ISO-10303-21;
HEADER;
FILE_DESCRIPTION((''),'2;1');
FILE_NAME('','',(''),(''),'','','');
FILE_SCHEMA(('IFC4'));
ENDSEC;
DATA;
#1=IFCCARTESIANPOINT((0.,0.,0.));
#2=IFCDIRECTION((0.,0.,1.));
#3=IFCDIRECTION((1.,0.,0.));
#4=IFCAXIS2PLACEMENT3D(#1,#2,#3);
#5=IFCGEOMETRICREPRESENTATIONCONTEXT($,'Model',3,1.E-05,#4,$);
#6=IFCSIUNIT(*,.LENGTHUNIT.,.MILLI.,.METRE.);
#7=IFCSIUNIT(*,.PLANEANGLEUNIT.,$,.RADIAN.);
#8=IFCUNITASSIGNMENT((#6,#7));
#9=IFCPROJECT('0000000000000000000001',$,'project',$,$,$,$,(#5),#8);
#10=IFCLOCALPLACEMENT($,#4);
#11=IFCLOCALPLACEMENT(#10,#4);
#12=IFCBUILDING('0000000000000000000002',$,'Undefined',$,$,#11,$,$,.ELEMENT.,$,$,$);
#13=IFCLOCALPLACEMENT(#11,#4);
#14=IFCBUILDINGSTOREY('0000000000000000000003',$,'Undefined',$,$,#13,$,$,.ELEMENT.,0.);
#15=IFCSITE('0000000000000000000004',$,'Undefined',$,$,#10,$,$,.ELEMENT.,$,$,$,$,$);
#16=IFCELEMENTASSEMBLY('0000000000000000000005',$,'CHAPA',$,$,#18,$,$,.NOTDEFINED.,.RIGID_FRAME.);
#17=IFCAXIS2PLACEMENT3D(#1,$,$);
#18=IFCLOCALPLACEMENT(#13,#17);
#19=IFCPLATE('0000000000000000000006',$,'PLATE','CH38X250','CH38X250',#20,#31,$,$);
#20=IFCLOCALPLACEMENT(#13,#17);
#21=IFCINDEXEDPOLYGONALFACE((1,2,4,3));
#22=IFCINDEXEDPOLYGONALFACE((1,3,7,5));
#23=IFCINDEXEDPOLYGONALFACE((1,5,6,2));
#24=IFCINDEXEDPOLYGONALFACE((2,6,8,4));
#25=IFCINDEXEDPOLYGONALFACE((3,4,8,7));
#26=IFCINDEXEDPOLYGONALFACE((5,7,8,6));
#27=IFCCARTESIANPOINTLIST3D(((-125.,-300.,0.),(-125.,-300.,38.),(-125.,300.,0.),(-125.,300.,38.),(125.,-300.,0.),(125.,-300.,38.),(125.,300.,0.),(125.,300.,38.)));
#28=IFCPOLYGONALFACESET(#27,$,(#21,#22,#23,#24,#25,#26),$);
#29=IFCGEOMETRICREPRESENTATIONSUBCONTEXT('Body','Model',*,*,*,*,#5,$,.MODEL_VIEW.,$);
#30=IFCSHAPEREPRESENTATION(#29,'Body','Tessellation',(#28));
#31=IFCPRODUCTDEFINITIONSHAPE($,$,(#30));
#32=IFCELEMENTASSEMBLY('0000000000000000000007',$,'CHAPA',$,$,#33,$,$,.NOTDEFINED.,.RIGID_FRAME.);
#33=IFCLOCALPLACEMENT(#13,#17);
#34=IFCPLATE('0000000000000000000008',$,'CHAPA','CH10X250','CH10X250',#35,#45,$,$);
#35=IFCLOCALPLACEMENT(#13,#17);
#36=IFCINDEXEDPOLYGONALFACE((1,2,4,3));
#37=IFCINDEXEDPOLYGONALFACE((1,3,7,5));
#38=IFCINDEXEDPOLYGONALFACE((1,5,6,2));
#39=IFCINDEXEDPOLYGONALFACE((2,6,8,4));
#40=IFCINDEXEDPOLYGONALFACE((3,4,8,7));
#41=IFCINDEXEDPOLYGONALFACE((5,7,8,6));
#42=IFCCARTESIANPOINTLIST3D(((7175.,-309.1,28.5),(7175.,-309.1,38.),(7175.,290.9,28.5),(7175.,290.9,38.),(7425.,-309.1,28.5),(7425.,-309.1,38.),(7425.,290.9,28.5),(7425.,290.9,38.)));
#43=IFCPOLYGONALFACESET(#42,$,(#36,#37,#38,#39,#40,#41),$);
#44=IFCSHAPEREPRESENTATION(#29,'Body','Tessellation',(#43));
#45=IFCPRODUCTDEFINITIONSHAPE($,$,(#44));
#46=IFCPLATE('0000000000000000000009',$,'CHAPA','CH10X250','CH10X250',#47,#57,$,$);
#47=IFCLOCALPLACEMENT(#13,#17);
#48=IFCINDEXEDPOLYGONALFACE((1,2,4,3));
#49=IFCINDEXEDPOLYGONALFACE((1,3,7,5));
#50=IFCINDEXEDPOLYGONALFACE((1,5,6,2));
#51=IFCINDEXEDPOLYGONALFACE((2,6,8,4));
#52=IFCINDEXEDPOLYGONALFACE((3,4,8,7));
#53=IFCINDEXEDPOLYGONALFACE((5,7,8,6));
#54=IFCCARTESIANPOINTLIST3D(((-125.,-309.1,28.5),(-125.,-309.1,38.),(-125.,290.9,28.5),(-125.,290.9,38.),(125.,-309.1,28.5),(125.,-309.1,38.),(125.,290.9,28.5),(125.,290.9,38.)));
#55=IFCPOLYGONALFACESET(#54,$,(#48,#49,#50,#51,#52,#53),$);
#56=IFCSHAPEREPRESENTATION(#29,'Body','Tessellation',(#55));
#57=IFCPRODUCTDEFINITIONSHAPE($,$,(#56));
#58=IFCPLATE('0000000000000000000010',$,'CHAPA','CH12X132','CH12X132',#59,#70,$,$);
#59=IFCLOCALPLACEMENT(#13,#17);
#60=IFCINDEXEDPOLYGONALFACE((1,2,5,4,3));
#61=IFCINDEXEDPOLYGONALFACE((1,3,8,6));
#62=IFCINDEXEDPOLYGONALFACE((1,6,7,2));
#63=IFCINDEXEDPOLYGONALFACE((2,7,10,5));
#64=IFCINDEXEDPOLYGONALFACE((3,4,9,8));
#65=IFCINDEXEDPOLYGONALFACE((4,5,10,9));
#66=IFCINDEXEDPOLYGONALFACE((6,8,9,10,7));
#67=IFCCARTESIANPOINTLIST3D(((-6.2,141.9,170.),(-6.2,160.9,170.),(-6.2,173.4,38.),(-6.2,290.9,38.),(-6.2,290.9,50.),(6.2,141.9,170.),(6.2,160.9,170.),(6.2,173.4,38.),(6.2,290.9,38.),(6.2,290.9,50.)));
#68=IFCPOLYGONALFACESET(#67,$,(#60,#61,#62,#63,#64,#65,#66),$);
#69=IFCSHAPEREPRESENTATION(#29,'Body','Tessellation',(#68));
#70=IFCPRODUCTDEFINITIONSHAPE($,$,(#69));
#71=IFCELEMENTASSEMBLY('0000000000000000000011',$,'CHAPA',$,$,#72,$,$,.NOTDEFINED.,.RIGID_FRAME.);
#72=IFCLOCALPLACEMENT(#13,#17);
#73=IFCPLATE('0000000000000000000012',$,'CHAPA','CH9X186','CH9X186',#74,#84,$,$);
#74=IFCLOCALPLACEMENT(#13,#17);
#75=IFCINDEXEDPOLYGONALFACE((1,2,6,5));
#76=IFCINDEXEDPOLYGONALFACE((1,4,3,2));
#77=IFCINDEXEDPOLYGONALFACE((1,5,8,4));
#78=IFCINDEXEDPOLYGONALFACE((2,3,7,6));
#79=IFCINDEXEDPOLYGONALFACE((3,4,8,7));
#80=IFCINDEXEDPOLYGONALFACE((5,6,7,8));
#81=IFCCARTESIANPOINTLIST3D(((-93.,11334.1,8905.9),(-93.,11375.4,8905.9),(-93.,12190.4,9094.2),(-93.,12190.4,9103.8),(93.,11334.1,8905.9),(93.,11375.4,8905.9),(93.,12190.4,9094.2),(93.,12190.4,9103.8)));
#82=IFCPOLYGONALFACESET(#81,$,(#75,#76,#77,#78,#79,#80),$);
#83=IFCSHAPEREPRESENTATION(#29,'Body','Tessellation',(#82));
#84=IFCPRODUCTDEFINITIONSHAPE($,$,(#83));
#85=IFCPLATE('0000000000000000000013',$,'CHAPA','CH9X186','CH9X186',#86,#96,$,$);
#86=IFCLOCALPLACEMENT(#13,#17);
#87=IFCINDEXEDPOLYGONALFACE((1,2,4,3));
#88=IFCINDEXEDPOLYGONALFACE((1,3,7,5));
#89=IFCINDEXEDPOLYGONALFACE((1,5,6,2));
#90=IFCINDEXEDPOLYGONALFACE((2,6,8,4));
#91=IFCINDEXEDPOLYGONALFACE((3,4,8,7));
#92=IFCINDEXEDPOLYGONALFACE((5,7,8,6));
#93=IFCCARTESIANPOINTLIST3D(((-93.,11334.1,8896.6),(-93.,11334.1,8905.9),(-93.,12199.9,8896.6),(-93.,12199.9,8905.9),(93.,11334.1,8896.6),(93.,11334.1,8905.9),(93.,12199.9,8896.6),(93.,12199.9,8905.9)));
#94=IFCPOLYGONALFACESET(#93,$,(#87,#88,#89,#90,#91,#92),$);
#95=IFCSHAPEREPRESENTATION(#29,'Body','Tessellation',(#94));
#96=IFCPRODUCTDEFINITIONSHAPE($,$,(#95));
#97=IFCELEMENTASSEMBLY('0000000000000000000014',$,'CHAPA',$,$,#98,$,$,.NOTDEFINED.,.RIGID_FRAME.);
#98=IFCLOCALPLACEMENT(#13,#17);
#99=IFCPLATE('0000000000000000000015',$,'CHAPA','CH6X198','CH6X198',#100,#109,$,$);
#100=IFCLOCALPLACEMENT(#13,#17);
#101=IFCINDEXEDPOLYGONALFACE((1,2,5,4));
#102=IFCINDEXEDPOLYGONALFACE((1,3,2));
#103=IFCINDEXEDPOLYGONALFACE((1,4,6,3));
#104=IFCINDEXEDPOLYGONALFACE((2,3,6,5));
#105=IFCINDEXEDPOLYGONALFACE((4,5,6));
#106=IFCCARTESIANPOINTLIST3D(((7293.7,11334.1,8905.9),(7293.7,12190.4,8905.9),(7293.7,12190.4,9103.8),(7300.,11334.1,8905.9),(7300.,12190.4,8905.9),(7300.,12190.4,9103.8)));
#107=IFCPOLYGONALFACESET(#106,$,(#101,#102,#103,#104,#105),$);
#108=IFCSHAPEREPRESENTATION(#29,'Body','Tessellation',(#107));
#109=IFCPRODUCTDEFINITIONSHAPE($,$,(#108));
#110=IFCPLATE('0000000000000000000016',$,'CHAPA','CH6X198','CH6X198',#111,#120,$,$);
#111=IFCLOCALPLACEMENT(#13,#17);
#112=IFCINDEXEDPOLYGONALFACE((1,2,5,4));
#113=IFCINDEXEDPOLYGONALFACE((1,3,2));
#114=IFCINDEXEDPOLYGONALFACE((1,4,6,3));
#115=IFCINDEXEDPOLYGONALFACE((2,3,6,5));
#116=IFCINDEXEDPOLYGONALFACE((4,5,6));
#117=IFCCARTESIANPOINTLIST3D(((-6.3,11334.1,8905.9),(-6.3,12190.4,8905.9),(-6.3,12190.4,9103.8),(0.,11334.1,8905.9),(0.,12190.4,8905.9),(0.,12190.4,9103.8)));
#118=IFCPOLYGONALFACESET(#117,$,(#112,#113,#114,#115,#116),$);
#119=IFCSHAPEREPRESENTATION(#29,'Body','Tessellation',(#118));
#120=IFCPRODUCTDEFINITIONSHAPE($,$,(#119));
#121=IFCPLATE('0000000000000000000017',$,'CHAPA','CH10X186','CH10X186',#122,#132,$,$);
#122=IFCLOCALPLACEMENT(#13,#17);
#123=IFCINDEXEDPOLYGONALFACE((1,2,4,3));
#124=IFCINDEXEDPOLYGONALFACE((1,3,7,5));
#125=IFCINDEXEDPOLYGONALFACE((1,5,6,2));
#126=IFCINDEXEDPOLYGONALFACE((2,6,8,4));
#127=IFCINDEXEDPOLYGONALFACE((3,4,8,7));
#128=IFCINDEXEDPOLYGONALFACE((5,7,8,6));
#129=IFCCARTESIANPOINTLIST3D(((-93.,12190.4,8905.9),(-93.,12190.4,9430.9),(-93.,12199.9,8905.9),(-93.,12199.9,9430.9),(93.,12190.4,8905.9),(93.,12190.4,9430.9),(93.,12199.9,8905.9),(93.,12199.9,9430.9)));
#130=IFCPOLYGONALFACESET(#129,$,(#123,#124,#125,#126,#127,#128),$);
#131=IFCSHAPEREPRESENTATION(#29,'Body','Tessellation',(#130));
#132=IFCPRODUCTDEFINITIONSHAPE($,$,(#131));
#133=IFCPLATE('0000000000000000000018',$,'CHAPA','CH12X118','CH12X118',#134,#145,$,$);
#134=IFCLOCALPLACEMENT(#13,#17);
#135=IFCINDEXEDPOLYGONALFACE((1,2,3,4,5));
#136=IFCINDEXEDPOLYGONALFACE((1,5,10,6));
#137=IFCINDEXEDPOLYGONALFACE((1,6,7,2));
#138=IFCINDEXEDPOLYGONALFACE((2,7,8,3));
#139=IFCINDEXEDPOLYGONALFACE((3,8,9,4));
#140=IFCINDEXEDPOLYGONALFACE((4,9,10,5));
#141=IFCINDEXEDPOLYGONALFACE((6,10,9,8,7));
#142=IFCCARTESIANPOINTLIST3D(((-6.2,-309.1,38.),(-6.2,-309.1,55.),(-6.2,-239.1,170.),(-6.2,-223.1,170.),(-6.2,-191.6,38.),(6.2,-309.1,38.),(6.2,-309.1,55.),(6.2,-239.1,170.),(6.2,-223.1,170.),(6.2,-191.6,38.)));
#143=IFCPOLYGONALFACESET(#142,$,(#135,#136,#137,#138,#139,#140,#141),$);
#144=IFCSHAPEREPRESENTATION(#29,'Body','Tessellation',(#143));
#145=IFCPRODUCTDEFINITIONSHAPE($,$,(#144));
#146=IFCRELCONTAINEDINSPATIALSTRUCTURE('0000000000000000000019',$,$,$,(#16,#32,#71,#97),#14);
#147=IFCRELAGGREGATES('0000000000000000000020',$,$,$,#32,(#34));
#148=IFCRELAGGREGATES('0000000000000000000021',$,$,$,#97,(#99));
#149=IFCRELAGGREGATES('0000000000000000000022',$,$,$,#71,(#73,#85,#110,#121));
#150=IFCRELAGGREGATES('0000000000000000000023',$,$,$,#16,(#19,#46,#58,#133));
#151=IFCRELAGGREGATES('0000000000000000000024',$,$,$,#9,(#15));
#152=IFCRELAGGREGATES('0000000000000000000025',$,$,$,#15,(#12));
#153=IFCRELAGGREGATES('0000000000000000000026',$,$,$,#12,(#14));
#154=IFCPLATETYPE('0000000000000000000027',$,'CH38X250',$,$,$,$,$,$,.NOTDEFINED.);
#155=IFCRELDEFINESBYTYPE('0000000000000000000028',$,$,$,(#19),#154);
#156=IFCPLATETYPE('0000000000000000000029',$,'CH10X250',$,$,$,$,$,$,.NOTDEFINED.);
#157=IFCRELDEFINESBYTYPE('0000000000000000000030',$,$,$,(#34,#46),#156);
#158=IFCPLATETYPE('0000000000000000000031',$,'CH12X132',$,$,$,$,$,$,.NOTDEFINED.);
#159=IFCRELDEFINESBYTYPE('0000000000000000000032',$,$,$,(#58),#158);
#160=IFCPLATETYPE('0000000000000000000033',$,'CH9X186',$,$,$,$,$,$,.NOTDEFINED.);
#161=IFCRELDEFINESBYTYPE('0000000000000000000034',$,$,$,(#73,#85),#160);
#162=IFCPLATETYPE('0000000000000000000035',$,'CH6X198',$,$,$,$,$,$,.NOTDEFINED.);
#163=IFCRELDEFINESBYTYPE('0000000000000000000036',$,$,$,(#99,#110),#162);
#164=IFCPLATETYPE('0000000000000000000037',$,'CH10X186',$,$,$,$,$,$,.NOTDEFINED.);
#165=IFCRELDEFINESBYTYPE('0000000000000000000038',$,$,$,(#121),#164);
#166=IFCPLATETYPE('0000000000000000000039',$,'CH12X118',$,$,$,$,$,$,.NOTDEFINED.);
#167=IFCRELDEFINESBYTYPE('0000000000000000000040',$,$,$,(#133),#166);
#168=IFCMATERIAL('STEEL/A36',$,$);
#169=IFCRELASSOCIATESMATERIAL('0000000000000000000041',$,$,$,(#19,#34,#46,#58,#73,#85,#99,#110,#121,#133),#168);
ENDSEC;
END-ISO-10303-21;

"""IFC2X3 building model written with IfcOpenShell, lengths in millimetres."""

from ifc_helpers import new_model, si_unit, frame, origin_with_axes, place, context, subcontext, project, spatial, polyline, outline, extrude, clip, halfspace, material, type_object, element, aggregate, save


model = new_model("IFC2X3")

# Units and contexts
model_context = context("Model", 3, precision=1e-05, world=origin_with_axes())
body_context = subcontext(model_context, "Body", "Model", "MODEL_VIEW")
ifc_project = project(units=[si_unit("LENGTHUNIT", "METRE", prefix="MILLI"), si_unit("PLANEANGLEUNIT", "RADIAN")], contexts=[model_context])

# Site, building, storey
site_placement = place(None, origin_with_axes())
site = spatial("IfcSite", under=ifc_project, at=site_placement, Name="Undefined", CompositionType="ELEMENT")
building_placement = place(site_placement, origin_with_axes())
building = spatial("IfcBuilding", under=site, at=building_placement, Name="Undefined", CompositionType="ELEMENT")
storey_placement = place(building_placement, origin_with_axes())
storey = spatial("IfcBuildingStorey", under=building, at=storey_placement, Name="Undefined", CompositionType="ELEMENT", Elevation=0.0)

# Element assembly, plate
assembly_1_placement = place(storey_placement, origin_with_axes())
assembly_1 = element("IfcElementAssembly", 1, at=assembly_1_placement, inside=storey, Name="CHAPA", AssemblyPlace="NOTDEFINED", PredefinedType="RIGID_FRAME")
ifc_material_1 = material(Name="STEEL/A36")
plate_type_1 = type_object("IfcPlateType", Name="CH38X250", PredefinedType="NOTDEFINED")
plate_1_placement = place(assembly_1_placement, frame((125.0, -300.0, 19.0), z_axis=(0.0, 0.0, 1.0), x_axis=(0.0, 1.0, 0.0)))
plate_1 = element("IfcPlate", 2, at=plate_1_placement, type_object=plate_type_1, material=ifc_material_1, Name="PLATE", Description="CH38X250", ObjectType="CH38X250", context=body_context, shape_type="SweptSolid", body=[
    extrude(outline(polyline([(0.0, 0.0), (600.0, 0.0), (600.0, 250.0), (0.0, 250.0), (0.0, 0.0)])), frame((0.0, 0.0, -19.0), z_axis=(0.0, 0.0, 1.0), x_axis=(1.0, 0.0, 0.0)), (0.0, 0.0, 1.0), 38.0),
])

# Element assembly, plate
assembly_2_placement = place(storey_placement, origin_with_axes())
assembly_2 = element("IfcElementAssembly", 3, at=assembly_2_placement, inside=storey, Name="CHAPA", AssemblyPlace="NOTDEFINED", PredefinedType="RIGID_FRAME")
plate_type_2 = type_object("IfcPlateType", Name="CH10X250", PredefinedType="NOTDEFINED")
plate_2_placement = place(assembly_2_placement, frame((7175.0, -309.1, 33.2), z_axis=(0.0, 0.0, 1.0), x_axis=(1.0, 0.0, 0.0)))
plate_2 = element("IfcPlate", 4, at=plate_2_placement, type_object=plate_type_2, material=ifc_material_1, Name="CHAPA", Description="CH10X250", ObjectType="CH10X250", context=body_context, shape_type="SweptSolid", body=[
    extrude(outline(polyline([(0.0, 0.0), (250.0, 0.0), (250.0, 600.0), (0.0, 600.0), (0.0, 0.0)])), frame((0.0, 0.0, -4.8), z_axis=(0.0, 0.0, 1.0), x_axis=(1.0, 0.0, 0.0)), (0.0, 0.0, 1.0), 9.5),
])
aggregate(assembly_2, [plate_2])

# Plates
plate_3_placement = place(assembly_1_placement, frame((-125.0, -309.1, 33.2), z_axis=(0.0, 0.0, 1.0), x_axis=(1.0, 0.0, 0.0)))
plate_3 = element("IfcPlate", 5, at=plate_3_placement, type_object=plate_type_2, material=ifc_material_1, Name="CHAPA", Description="CH10X250", ObjectType="CH10X250", context=body_context, shape_type="SweptSolid", body=[
    extrude(outline(polyline([(0.0, 0.0), (250.0, 0.0), (250.0, 600.0), (0.0, 600.0), (0.0, 0.0)])), frame((0.0, 0.0, -4.8), z_axis=(0.0, 0.0, 1.0), x_axis=(1.0, 0.0, 0.0)), (0.0, 0.0, 1.0), 9.5),
])
plate_type_3 = type_object("IfcPlateType", Name="CH12X132", PredefinedType="NOTDEFINED")
plate_4_placement = place(assembly_1_placement, frame((0.0, 173.4, 38.0), z_axis=(1.0, 0.0, 0.0), x_axis=(0.0, 1.0, 0.0)))
plate_4 = element("IfcPlate", 6, at=plate_4_placement, type_object=plate_type_3, material=ifc_material_1, Name="CHAPA", Description="CH12X132", ObjectType="CH12X132", context=body_context, shape_type="SweptSolid", body=[
    extrude(outline(polyline([(0.0, 0.0), (117.5, 0.0), (117.5, 12.0), (-12.5, 132.0), (-31.6, 132.0), (0.0, 0.0)])), frame((0.0, 0.0, -6.2), z_axis=(0.0, 0.0, 1.0), x_axis=(1.0, 0.0, 0.0)), (0.0, 0.0, 1.0), 12.5),
])

# Element assembly, plates
assembly_3_placement = place(storey_placement, origin_with_axes())
assembly_3 = element("IfcElementAssembly", 7, at=assembly_3_placement, inside=storey, Name="CHAPA", AssemblyPlace="NOTDEFINED", PredefinedType="RIGID_FRAME")
plate_type_4 = type_object("IfcPlateType", Name="CH9X186", PredefinedType="NOTDEFINED")
plate_5_placement = place(assembly_3_placement, frame((93.0, 12191.4, 9099.3), z_axis=(0.0, -0.225125, 0.97433), x_axis=(-1.0, 0.0, 0.0)))
plate_5 = element("IfcPlate", 8, at=plate_5_placement, type_object=plate_type_4, material=ifc_material_1, Name="CHAPA", Description="CH9X186", ObjectType="CH9X186", context=body_context, shape_type="Clipping", body=[
    clip(clip(extrude(outline(polyline([(0.0, 0.0), (186.0, 0.0), (186.0, 878.9), (0.0, 878.9), (0.0, 0.0)])), frame((0.0, 0.0, -4.7), z_axis=(0.0, 0.0, 1.0), x_axis=(1.0, 0.0, 0.0)), (0.0, 0.0, 1.0), 9.3), halfspace(frame((186.0, -500.0, -314.0), z_axis=(0.0, 0.225128, -0.974329), x_axis=(0.0, 0.974329, 0.225128)), False)), halfspace(frame((0.0, 2.1, -4.6), z_axis=(0.0, -0.97433, -0.225125), x_axis=(0.0, -0.225125, 0.97433)), False)),
])
plate_6_placement = place(assembly_3_placement, frame((93.0, 12199.9, 8901.3), z_axis=(0.0, 0.0, 1.0), x_axis=(-1.0, 0.0, 0.0)))
plate_6 = element("IfcPlate", 9, at=plate_6_placement, type_object=plate_type_4, material=ifc_material_1, Name="CHAPA", Description="CH9X186", ObjectType="CH9X186", context=body_context, shape_type="SweptSolid", body=[
    extrude(outline(polyline([(0.0, 0.0), (186.0, 0.0), (186.0, 865.8), (0.0, 865.8), (0.0, 0.0)])), frame((0.0, 0.0, -4.7), z_axis=(0.0, 0.0, 1.0), x_axis=(1.0, 0.0, 0.0)), (0.0, 0.0, 1.0), 9.3),
])

# Element assembly, plate
assembly_4_placement = place(storey_placement, origin_with_axes())
assembly_4 = element("IfcElementAssembly", 10, at=assembly_4_placement, inside=storey, Name="CHAPA", AssemblyPlace="NOTDEFINED", PredefinedType="RIGID_FRAME")
plate_type_5 = type_object("IfcPlateType", Name="CH6X198", PredefinedType="NOTDEFINED")
plate_7_placement = place(assembly_4_placement, frame((7296.9, 11334.1, 8905.9), z_axis=(1.0, 0.0, 0.0), x_axis=(0.0, 1.0, 0.0)))
plate_7 = element("IfcPlate", 11, at=plate_7_placement, type_object=plate_type_5, material=ifc_material_1, Name="CHAPA", Description="CH6X198", ObjectType="CH6X198", context=body_context, shape_type="SweptSolid", body=[
    extrude(outline(polyline([(0.0, 0.0), (856.3, 0.0), (856.3, 197.9), (0.0, 0.0)])), frame((0.0, 0.0, -3.1), z_axis=(0.0, 0.0, 1.0), x_axis=(1.0, 0.0, 0.0)), (0.0, 0.0, 1.0), 6.3),
])
aggregate(assembly_4, [plate_7])

# Plates
plate_8_placement = place(assembly_3_placement, frame((-3.1, 11334.1, 8905.9), z_axis=(1.0, 0.0, 0.0), x_axis=(0.0, 1.0, 0.0)))
plate_8 = element("IfcPlate", 12, at=plate_8_placement, type_object=plate_type_5, material=ifc_material_1, Name="CHAPA", Description="CH6X198", ObjectType="CH6X198", context=body_context, shape_type="SweptSolid", body=[
    extrude(outline(polyline([(0.0, 0.0), (856.3, 0.0), (856.3, 197.9), (0.0, 0.0)])), frame((0.0, 0.0, -3.1), z_axis=(0.0, 0.0, 1.0), x_axis=(1.0, 0.0, 0.0)), (0.0, 0.0, 1.0), 6.3),
])
plate_type_6 = type_object("IfcPlateType", Name="CH10X186", PredefinedType="NOTDEFINED")
plate_9_placement = place(assembly_3_placement, frame((93.0, 12195.2, 9430.9), z_axis=(0.0, -1.0, 0.0), x_axis=(-1.0, 0.0, 0.0)))
plate_9 = element("IfcPlate", 13, at=plate_9_placement, type_object=plate_type_6, material=ifc_material_1, Name="CHAPA", Description="CH10X186", ObjectType="CH10X186", context=body_context, shape_type="SweptSolid", body=[
    extrude(outline(polyline([(0.0, 0.0), (186.0, 0.0), (186.0, 525.0), (0.0, 525.0), (0.0, 0.0)])), frame((0.0, 0.0, -4.8), z_axis=(0.0, 0.0, 1.0), x_axis=(1.0, 0.0, 0.0)), (0.0, 0.0, 1.0), 9.5),
])
aggregate(assembly_3, [plate_5, plate_6, plate_8, plate_9])
plate_type_7 = type_object("IfcPlateType", Name="CH12X118", PredefinedType="NOTDEFINED")
plate_10_placement = place(assembly_1_placement, frame((0.0, -309.1, 38.0), z_axis=(1.0, 0.0, 0.0), x_axis=(0.0, 1.0, 0.0)))
plate_10 = element("IfcPlate", 14, at=plate_10_placement, type_object=plate_type_7, material=ifc_material_1, Name="CHAPA", Description="CH12X118", ObjectType="CH12X118", context=body_context, shape_type="SweptSolid", body=[
    extrude(outline(polyline([(0.0, 0.0), (117.5, 0.0), (85.9, 132.0), (70.0, 132.0), (0.0, 17.0), (0.0, 0.0)])), frame((0.0, 0.0, -6.2), z_axis=(0.0, 0.0, 1.0), x_axis=(1.0, 0.0, 0.0)), (0.0, 0.0, 1.0), 12.5),
])

aggregate(assembly_1, [plate_1, plate_3, plate_4, plate_10])

save(model, "model.ifc")
